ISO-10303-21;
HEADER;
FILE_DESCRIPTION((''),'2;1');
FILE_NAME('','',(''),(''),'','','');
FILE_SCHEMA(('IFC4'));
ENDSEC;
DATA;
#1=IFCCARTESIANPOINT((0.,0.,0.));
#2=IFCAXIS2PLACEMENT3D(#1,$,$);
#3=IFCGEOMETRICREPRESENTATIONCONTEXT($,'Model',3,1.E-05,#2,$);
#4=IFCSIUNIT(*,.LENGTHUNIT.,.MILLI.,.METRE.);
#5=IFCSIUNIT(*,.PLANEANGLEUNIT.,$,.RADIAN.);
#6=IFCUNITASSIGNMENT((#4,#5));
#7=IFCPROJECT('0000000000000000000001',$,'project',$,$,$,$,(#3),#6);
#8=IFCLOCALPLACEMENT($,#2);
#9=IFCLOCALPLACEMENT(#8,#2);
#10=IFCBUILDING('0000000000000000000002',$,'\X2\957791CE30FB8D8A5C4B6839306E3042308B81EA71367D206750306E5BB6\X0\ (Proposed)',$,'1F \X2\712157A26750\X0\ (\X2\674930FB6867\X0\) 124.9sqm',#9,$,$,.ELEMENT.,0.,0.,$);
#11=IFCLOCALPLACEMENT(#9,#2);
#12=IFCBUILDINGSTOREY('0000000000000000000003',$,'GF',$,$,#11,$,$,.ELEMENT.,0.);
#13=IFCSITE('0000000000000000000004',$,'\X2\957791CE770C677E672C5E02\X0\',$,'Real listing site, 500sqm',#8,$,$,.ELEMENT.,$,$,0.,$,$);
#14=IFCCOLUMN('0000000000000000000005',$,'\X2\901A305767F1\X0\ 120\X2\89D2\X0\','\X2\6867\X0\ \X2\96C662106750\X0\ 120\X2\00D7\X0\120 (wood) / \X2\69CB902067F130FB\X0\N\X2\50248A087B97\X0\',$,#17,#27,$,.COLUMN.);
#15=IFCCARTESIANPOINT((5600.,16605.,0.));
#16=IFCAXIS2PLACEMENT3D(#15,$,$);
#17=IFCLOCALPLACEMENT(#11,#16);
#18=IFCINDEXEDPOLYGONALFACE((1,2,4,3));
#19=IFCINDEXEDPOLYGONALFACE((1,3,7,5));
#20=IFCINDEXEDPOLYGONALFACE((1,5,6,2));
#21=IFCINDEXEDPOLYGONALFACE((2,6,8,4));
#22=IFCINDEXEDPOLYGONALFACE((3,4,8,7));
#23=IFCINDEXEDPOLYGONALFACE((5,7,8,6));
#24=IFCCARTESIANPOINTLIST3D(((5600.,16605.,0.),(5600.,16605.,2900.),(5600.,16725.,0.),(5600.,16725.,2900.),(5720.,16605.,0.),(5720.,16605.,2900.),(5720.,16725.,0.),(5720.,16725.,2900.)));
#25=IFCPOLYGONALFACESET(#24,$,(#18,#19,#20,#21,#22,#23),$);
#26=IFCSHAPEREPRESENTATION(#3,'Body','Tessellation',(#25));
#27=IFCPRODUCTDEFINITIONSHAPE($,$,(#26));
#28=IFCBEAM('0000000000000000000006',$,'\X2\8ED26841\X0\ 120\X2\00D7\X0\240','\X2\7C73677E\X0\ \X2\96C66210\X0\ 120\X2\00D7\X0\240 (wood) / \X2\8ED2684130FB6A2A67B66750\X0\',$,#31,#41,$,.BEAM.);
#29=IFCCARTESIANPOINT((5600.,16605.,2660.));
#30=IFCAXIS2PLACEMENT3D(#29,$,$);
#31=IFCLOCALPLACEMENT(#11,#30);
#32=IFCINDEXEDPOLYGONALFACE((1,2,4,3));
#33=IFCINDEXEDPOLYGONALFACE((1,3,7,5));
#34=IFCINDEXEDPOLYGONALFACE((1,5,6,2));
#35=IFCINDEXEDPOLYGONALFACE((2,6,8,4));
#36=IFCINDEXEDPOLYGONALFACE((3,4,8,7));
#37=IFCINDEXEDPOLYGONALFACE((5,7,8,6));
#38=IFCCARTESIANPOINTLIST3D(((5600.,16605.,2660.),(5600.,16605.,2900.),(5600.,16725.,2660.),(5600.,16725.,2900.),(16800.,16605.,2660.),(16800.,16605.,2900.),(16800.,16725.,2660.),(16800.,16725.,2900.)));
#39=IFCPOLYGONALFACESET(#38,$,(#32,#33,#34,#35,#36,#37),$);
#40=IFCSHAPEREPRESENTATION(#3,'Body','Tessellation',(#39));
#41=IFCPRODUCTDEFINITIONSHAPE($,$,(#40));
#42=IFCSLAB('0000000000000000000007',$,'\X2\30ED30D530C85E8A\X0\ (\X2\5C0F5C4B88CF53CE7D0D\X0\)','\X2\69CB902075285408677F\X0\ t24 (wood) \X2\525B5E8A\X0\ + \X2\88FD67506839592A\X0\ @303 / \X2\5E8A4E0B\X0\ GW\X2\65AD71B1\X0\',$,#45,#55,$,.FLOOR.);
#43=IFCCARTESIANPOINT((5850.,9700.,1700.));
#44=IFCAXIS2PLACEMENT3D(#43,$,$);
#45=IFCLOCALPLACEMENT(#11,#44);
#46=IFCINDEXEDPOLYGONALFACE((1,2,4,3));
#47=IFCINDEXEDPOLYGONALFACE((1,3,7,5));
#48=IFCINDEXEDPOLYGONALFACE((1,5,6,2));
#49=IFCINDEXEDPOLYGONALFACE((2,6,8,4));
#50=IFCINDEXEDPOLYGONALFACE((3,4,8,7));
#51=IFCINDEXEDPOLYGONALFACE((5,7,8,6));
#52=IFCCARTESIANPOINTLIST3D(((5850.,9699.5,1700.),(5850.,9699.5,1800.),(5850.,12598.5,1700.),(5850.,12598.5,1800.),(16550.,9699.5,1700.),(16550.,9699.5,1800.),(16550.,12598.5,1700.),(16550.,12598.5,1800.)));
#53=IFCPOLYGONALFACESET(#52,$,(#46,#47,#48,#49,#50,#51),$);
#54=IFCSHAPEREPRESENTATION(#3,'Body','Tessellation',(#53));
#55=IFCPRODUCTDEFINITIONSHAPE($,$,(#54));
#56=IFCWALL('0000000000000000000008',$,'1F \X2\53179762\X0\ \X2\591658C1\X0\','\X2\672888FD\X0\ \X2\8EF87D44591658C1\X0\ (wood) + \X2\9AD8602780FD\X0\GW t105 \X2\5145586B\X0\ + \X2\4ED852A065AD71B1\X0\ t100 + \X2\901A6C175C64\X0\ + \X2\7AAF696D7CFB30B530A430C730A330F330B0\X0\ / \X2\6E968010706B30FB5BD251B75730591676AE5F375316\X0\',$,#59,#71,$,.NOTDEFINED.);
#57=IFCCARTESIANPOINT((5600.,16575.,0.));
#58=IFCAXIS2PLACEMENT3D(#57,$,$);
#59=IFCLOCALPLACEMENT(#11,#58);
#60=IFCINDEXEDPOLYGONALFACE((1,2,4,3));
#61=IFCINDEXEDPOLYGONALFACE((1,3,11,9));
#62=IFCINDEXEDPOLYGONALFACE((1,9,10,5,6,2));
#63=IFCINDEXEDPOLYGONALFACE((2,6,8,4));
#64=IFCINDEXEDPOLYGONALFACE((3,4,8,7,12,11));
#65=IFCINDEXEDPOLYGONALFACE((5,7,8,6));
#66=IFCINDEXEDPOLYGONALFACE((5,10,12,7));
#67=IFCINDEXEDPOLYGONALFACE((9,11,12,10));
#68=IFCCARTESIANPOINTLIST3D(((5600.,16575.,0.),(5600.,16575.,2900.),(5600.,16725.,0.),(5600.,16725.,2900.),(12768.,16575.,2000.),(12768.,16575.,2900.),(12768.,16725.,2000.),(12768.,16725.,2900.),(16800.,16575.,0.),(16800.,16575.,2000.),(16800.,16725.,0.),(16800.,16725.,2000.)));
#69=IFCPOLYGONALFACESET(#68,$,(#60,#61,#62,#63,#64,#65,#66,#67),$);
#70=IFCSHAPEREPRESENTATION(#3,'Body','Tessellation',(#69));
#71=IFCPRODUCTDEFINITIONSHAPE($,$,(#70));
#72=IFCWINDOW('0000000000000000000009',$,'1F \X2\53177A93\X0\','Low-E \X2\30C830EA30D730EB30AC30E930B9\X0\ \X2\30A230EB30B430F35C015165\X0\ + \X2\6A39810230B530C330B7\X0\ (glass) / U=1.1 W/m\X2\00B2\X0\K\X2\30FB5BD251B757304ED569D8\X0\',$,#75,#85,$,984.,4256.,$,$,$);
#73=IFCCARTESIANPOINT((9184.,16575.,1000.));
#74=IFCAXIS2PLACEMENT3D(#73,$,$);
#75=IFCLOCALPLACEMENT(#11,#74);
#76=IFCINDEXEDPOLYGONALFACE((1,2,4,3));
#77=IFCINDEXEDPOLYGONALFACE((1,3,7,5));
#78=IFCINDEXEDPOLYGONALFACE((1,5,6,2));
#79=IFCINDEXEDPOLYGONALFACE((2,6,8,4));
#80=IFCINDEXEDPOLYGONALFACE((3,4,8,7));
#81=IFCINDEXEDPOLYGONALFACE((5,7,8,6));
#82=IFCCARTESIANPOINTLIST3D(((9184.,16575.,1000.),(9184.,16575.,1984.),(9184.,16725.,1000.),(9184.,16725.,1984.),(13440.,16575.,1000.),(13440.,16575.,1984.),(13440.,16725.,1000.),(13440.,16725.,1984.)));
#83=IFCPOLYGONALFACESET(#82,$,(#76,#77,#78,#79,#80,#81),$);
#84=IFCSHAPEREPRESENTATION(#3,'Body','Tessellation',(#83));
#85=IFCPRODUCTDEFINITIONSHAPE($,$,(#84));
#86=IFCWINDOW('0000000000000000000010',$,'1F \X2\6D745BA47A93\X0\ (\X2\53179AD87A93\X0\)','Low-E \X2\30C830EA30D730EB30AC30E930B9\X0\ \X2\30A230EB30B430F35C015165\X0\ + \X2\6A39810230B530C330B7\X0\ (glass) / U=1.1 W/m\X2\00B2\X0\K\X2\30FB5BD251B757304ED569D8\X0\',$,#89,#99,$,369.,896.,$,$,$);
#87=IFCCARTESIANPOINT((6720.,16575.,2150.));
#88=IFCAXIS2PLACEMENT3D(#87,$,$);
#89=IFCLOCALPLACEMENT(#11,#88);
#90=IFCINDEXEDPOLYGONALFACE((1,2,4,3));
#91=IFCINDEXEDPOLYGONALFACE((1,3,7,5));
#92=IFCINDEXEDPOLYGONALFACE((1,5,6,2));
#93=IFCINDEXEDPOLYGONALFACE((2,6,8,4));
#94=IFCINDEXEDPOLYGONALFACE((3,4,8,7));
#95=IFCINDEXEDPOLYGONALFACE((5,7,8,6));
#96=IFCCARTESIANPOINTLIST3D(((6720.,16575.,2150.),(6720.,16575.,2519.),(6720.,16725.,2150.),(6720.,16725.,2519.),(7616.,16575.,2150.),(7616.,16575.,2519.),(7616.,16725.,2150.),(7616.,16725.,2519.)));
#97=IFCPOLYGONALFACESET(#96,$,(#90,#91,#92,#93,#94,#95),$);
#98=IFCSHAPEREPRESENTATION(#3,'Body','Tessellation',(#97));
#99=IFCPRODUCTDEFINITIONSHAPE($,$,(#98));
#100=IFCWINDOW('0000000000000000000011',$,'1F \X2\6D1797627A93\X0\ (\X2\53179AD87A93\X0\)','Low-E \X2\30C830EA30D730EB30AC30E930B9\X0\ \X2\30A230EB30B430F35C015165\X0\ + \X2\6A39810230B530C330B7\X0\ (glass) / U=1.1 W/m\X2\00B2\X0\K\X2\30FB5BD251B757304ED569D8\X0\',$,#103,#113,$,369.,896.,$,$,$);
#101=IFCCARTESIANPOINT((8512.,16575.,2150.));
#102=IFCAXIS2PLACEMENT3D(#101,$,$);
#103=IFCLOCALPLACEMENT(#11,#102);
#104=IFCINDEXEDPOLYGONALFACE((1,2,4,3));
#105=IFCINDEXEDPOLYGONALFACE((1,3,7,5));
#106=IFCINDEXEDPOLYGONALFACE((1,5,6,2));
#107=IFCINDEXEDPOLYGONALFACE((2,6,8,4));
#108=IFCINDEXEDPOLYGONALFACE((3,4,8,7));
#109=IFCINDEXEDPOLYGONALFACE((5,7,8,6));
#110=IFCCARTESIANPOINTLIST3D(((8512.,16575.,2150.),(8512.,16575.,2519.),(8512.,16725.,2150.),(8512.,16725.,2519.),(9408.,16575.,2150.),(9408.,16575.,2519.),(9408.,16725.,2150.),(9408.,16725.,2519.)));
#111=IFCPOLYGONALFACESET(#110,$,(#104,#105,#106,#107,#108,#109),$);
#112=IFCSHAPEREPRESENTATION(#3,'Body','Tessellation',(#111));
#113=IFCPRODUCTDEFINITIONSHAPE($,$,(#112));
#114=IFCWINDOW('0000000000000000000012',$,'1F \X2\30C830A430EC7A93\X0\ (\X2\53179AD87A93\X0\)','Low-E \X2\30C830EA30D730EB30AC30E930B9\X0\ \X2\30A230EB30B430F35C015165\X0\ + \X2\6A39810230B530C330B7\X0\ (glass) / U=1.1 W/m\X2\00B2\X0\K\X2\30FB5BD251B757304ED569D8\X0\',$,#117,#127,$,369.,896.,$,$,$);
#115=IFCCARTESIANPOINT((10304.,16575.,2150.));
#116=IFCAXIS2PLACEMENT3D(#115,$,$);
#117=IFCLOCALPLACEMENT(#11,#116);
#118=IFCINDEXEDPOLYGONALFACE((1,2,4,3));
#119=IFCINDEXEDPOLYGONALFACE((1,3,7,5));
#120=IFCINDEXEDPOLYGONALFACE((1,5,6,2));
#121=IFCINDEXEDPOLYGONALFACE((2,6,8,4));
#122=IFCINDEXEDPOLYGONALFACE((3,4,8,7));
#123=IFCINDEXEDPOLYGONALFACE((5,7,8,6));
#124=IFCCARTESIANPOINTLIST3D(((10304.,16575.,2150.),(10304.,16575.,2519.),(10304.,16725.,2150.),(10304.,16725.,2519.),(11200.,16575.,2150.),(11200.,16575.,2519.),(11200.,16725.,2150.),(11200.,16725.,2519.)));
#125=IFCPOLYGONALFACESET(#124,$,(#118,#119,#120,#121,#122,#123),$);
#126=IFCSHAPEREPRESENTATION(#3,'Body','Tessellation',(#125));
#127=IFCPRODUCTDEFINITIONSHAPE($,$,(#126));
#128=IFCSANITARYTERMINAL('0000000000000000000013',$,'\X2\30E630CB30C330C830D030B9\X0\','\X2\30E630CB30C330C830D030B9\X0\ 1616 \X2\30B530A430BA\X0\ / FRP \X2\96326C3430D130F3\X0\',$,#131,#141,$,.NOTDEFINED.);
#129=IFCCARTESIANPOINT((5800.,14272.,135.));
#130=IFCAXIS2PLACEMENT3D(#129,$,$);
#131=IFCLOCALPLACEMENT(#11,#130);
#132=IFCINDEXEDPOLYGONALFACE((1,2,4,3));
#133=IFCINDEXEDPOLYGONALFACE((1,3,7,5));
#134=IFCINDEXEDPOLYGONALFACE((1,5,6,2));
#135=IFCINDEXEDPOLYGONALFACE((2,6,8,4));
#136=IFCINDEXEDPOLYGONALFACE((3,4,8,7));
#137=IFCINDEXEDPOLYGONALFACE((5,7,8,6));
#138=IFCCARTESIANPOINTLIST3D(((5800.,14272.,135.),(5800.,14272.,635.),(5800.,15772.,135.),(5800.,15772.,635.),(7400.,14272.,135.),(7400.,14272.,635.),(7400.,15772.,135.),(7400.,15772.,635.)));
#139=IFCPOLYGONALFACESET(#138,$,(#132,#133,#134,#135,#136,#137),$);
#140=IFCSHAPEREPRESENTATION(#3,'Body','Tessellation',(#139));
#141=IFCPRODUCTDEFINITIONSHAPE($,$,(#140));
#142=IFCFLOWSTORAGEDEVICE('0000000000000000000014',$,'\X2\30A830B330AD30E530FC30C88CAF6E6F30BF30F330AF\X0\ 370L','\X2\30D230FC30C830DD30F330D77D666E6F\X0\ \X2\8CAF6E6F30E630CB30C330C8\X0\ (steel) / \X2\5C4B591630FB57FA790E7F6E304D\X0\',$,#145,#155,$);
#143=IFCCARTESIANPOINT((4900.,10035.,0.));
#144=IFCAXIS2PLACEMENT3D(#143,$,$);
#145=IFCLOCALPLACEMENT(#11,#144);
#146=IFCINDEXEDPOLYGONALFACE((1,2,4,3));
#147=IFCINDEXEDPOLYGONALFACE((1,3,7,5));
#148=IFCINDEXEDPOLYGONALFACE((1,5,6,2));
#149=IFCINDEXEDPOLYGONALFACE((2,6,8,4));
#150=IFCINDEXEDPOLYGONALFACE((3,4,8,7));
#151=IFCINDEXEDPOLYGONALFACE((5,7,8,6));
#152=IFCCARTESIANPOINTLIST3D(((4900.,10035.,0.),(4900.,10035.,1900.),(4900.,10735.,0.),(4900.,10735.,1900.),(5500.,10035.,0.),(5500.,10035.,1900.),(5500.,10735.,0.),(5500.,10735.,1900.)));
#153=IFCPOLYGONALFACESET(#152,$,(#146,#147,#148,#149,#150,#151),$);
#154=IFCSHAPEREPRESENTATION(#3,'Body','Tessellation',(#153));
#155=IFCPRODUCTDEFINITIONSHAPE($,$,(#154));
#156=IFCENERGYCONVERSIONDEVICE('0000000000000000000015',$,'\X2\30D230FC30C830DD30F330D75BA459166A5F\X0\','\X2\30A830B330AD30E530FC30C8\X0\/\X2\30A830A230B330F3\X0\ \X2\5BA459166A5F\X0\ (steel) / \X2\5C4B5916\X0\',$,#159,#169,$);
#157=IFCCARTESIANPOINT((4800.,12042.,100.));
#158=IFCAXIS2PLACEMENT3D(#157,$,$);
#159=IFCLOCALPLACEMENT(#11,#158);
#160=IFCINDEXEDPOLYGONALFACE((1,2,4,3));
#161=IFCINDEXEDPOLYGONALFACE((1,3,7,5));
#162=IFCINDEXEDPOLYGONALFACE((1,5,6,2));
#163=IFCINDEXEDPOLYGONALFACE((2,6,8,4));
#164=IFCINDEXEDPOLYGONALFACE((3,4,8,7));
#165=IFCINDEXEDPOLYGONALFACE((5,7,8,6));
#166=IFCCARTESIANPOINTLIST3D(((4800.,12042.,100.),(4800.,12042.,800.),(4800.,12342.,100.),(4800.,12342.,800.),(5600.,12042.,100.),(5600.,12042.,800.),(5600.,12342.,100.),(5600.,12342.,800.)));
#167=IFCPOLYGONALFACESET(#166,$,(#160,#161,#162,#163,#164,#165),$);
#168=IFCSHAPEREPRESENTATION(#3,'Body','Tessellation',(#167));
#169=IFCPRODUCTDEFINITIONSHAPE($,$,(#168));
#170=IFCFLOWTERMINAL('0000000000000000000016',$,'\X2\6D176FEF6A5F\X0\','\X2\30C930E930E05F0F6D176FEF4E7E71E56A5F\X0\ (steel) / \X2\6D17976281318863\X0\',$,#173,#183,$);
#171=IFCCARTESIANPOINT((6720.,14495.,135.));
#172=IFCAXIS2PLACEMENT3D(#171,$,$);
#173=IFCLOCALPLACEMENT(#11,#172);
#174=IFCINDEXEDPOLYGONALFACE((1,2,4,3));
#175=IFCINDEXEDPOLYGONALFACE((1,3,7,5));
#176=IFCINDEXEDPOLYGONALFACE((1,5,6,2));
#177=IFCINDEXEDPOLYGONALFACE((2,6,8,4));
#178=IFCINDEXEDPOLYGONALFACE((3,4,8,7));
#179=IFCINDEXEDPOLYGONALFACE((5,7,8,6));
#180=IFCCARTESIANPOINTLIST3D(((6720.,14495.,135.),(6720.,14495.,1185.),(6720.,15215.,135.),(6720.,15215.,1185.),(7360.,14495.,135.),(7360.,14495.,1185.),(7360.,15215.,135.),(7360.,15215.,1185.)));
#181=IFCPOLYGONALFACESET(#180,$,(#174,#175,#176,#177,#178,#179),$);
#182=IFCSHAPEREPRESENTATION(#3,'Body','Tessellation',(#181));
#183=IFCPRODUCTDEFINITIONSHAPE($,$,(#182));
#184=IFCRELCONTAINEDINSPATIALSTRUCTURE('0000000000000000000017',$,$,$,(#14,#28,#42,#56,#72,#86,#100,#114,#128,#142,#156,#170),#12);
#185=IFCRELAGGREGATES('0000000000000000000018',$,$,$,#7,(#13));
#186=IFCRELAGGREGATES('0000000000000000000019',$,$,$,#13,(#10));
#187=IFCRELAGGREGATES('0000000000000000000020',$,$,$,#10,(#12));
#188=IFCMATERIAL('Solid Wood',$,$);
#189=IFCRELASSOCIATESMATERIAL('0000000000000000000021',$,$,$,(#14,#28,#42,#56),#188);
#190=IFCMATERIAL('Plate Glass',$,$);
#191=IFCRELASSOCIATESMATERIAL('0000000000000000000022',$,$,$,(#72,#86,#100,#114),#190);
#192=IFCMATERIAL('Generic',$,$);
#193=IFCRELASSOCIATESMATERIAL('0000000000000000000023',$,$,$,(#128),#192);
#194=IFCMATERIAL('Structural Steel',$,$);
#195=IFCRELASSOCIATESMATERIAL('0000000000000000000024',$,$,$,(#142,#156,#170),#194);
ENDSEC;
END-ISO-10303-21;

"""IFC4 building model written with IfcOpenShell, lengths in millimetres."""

from ifc_helpers import new_model, si_unit, frame, frame_2d, origin, place, context, project, spatial, rectangle, extrude, material, element, fill, save


model = new_model("IFC4")

# Units and contexts
model_context = context("Model", 3, precision=1e-05, world=origin())
ifc_project = project(units=[si_unit("LENGTHUNIT", "METRE", prefix="MILLI"), si_unit("PLANEANGLEUNIT", "RADIAN")], contexts=[model_context])

# Site, building, storey
site_placement = place(None, origin())
site = spatial("IfcSite", under=ifc_project, at=site_placement, Name="長野県松本市", ObjectType="Real listing site, 500sqm", CompositionType="ELEMENT", RefElevation=0.0)
building_placement = place(site_placement, origin())
building = spatial("IfcBuilding", under=site, at=building_placement, Name="長野・越屋根のある自然素材の家 (Proposed)", ObjectType="1F 無垢材 (杉・桧) 124.9sqm", CompositionType="ELEMENT", ElevationOfRefHeight=0.0, ElevationOfTerrain=0.0)
storey_placement = place(building_placement, origin())
storey = spatial("IfcBuildingStorey", under=building, at=storey_placement, Name="GF", CompositionType="ELEMENT", Elevation=0.0)

# Column
ifc_material_1 = material(Name="Solid Wood")
column_1_placement = place(storey_placement, frame((5600.0, 16605.0, 0.0)))
element("IfcColumn", 1, at=column_1_placement, inside=storey, material=ifc_material_1, Name="通し柱 120角", Description="桧 集成材 120×120 (wood) / 構造柱・N値計算", PredefinedType="COLUMN", context=model_context, shape_type="SweptSolid", body=[
    extrude(rectangle(XDim=120.0, YDim=120.0, at=frame_2d((60.0, 60.0))), frame((5600.0, 16605.0, 0.0)), (0.0, 0.0, 1.0), 2900.0),
])

# Beam
beam_1_placement = place(storey_placement, frame((5600.0, 16605.0, 2660.0)))
element("IfcBeam", 2, at=beam_1_placement, inside=storey, material=ifc_material_1, Name="軒桁 120×240", Description="米松 集成 120×240 (wood) / 軒桁・横架材", PredefinedType="BEAM", context=model_context, shape_type="SweptSolid", body=[
    extrude(rectangle(XDim=11200.0, YDim=120.0, at=frame_2d((5600.0, 60.0))), frame((5600.0, 16605.0, 2660.0)), (0.0, 0.0, 1.0), 240.0),
])

# Slab
slab_placement = place(storey_placement, frame((5850.0, 9700.0, 1700.0)))
element("IfcSlab", 3, at=slab_placement, inside=storey, material=ifc_material_1, Name="ロフト床 (小屋裏収納)", Description="構造用合板 t24 (wood) 剛床 + 製材根太 @303 / 床下 GW断熱", PredefinedType="FLOOR", context=model_context, shape_type="SweptSolid", body=[
    extrude(rectangle(XDim=10700.0, YDim=2899.0, at=frame_2d((5350.0, 1449.0))), frame((5850.0, 9700.0, 1700.0)), (0.0, 0.0, 1.0), 100.0),
])

# Wall, openings, windows
wall_1_placement = place(storey_placement, frame((5600.0, 16575.0, 0.0)))
wall_1 = element("IfcWall", 4, at=wall_1_placement, inside=storey, material=ifc_material_1, Name="1F 北面 外壁", Description="木製 軸組外壁 (wood) + 高性能GW t105 充填 + 付加断熱 t100 + 通気層 + 窯業系サイディング / 準耐火・寒冷地外皮強化", PredefinedType="NOTDEFINED", context=model_context, shape_type="SweptSolid", body=[
    extrude(rectangle(XDim=11200.0, YDim=150.0, at=frame_2d((5600.0, 75.0))), frame((5600.0, 16575.0, 0.0)), (0.0, 0.0, 1.0), 2900.0),
])
opening_1_placement = place(storey_placement, frame((9184.0, 16575.0, 1000.0)))
opening_1 = element("IfcOpeningElement", 5, at=opening_1_placement, cuts=wall_1, PredefinedType="NOTDEFINED", context=model_context, shape_type="SweptSolid", body=[
    extrude(rectangle(XDim=4256.0, YDim=150.0, at=frame_2d((2128.0, 75.0))), frame((9184.0, 16575.0, 1000.0)), (0.0, 0.0, 1.0), 984.0),
])
opening_2_placement = place(storey_placement, frame((6720.0, 16575.0, 2150.0)))
opening_2 = element("IfcOpeningElement", 6, at=opening_2_placement, cuts=wall_1, PredefinedType="NOTDEFINED", context=model_context, shape_type="SweptSolid", body=[
    extrude(rectangle(XDim=896.0, YDim=150.0, at=frame_2d((448.0, 75.0))), frame((6720.0, 16575.0, 2150.0)), (0.0, 0.0, 1.0), 369.0),
])
opening_3_placement = place(storey_placement, frame((8512.0, 16575.0, 2150.0)))
opening_3 = element("IfcOpeningElement", 7, at=opening_3_placement, cuts=wall_1, PredefinedType="NOTDEFINED", context=model_context, shape_type="SweptSolid", body=[
    extrude(rectangle(XDim=896.0, YDim=150.0, at=frame_2d((448.0, 75.0))), frame((8512.0, 16575.0, 2150.0)), (0.0, 0.0, 1.0), 369.0),
])
opening_4_placement = place(storey_placement, frame((10304.0, 16575.0, 2150.0)))
opening_4 = element("IfcOpeningElement", 8, at=opening_4_placement, cuts=wall_1, PredefinedType="NOTDEFINED", context=model_context, shape_type="SweptSolid", body=[
    extrude(rectangle(XDim=896.0, YDim=150.0, at=frame_2d((448.0, 75.0))), frame((10304.0, 16575.0, 2150.0)), (0.0, 0.0, 1.0), 369.0),
])
ifc_material_2 = material(Name="Plate Glass")
window_1_placement = place(storey_placement, frame((9184.0, 16575.0, 1000.0)))
window_1 = element("IfcWindow", 9, at=window_1_placement, inside=storey, material=ifc_material_2, Name="1F 北窓", Description="Low-E トリプルガラス アルゴン封入 + 樹脂サッシ (glass) / U=1.1 W/m²K・寒冷地仕様", OverallHeight=984.0, OverallWidth=4256.0, context=model_context, shape_type="SweptSolid", body=[
    extrude(rectangle(XDim=4256.0, YDim=150.0, at=frame_2d((2128.0, 75.0))), frame((9184.0, 16575.0, 1000.0)), (0.0, 0.0, 1.0), 984.0),
])
fill(opening_1, window_1)
window_2_placement = place(storey_placement, frame((6720.0, 16575.0, 2150.0)))
window_2 = element("IfcWindow", 10, at=window_2_placement, inside=storey, material=ifc_material_2, Name="1F 浴室窓 (北高窓)", Description="Low-E トリプルガラス アルゴン封入 + 樹脂サッシ (glass) / U=1.1 W/m²K・寒冷地仕様", OverallHeight=369.0, OverallWidth=896.0, context=model_context, shape_type="SweptSolid", body=[
    extrude(rectangle(XDim=896.0, YDim=150.0, at=frame_2d((448.0, 75.0))), frame((6720.0, 16575.0, 2150.0)), (0.0, 0.0, 1.0), 369.0),
])
fill(opening_2, window_2)
window_3_placement = place(storey_placement, frame((8512.0, 16575.0, 2150.0)))
window_3 = element("IfcWindow", 11, at=window_3_placement, inside=storey, material=ifc_material_2, Name="1F 洗面窓 (北高窓)", Description="Low-E トリプルガラス アルゴン封入 + 樹脂サッシ (glass) / U=1.1 W/m²K・寒冷地仕様", OverallHeight=369.0, OverallWidth=896.0, context=model_context, shape_type="SweptSolid", body=[
    extrude(rectangle(XDim=896.0, YDim=150.0, at=frame_2d((448.0, 75.0))), frame((8512.0, 16575.0, 2150.0)), (0.0, 0.0, 1.0), 369.0),
])
fill(opening_3, window_3)
window_4_placement = place(storey_placement, frame((10304.0, 16575.0, 2150.0)))
window_4 = element("IfcWindow", 12, at=window_4_placement, inside=storey, material=ifc_material_2, Name="1F トイレ窓 (北高窓)", Description="Low-E トリプルガラス アルゴン封入 + 樹脂サッシ (glass) / U=1.1 W/m²K・寒冷地仕様", OverallHeight=369.0, OverallWidth=896.0, context=model_context, shape_type="SweptSolid", body=[
    extrude(rectangle(XDim=896.0, YDim=150.0, at=frame_2d((448.0, 75.0))), frame((10304.0, 16575.0, 2150.0)), (0.0, 0.0, 1.0), 369.0),
])
fill(opening_4, window_4)

# Sanitary terminal
ifc_material_3 = material(Name="Generic")
sanitary_terminal_placement = place(storey_placement, frame((5800.0, 14272.0, 135.0)))
element("IfcSanitaryTerminal", 13, at=sanitary_terminal_placement, inside=storey, material=ifc_material_3, Name="ユニットバス", Description="ユニットバス 1616 サイズ / FRP 防水パン", PredefinedType="NOTDEFINED", context=model_context, shape_type="SweptSolid", body=[
    extrude(rectangle(XDim=1600.0, YDim=1500.0, at=frame_2d((800.0, 750.0))), frame((5800.0, 14272.0, 135.0)), (0.0, 0.0, 1.0), 500.0),
])

# Flow storage device
ifc_material_4 = material(Name="Structural Steel")
flow_storage_device_placement = place(storey_placement, frame((4900.0, 10035.0, 0.0)))
element("IfcFlowStorageDevice", 14, at=flow_storage_device_placement, inside=storey, material=ifc_material_4, Name="エコキュート貯湯タンク 370L", Description="ヒートポンプ給湯 貯湯ユニット (steel) / 屋外・基礎置き", context=model_context, shape_type="SweptSolid", body=[
    extrude(rectangle(XDim=600.0, YDim=700.0, at=frame_2d((300.0, 350.0))), frame((4900.0, 10035.0, 0.0)), (0.0, 0.0, 1.0), 1900.0),
])

# Energy conversion device
energy_conversion_device_placement = place(storey_placement, frame((4800.0, 12042.0, 100.0)))
element("IfcEnergyConversionDevice", 15, at=energy_conversion_device_placement, inside=storey, material=ifc_material_4, Name="ヒートポンプ室外機", Description="エコキュート/エアコン 室外機 (steel) / 屋外", context=model_context, shape_type="SweptSolid", body=[
    extrude(rectangle(XDim=800.0, YDim=300.0, at=frame_2d((400.0, 150.0))), frame((4800.0, 12042.0, 100.0)), (0.0, 0.0, 1.0), 700.0),
])

# Flow terminal
flow_terminal_placement = place(storey_placement, frame((6720.0, 14495.0, 135.0)))
element("IfcFlowTerminal", 16, at=flow_terminal_placement, inside=storey, material=ifc_material_4, Name="洗濯機", Description="ドラム式洗濯乾燥機 (steel) / 洗面脱衣", context=model_context, shape_type="SweptSolid", body=[
    extrude(rectangle(XDim=640.0, YDim=720.0, at=frame_2d((320.0, 360.0))), frame((6720.0, 14495.0, 135.0)), (0.0, 0.0, 1.0), 1050.0),
])

save(model, "model.ifc")
